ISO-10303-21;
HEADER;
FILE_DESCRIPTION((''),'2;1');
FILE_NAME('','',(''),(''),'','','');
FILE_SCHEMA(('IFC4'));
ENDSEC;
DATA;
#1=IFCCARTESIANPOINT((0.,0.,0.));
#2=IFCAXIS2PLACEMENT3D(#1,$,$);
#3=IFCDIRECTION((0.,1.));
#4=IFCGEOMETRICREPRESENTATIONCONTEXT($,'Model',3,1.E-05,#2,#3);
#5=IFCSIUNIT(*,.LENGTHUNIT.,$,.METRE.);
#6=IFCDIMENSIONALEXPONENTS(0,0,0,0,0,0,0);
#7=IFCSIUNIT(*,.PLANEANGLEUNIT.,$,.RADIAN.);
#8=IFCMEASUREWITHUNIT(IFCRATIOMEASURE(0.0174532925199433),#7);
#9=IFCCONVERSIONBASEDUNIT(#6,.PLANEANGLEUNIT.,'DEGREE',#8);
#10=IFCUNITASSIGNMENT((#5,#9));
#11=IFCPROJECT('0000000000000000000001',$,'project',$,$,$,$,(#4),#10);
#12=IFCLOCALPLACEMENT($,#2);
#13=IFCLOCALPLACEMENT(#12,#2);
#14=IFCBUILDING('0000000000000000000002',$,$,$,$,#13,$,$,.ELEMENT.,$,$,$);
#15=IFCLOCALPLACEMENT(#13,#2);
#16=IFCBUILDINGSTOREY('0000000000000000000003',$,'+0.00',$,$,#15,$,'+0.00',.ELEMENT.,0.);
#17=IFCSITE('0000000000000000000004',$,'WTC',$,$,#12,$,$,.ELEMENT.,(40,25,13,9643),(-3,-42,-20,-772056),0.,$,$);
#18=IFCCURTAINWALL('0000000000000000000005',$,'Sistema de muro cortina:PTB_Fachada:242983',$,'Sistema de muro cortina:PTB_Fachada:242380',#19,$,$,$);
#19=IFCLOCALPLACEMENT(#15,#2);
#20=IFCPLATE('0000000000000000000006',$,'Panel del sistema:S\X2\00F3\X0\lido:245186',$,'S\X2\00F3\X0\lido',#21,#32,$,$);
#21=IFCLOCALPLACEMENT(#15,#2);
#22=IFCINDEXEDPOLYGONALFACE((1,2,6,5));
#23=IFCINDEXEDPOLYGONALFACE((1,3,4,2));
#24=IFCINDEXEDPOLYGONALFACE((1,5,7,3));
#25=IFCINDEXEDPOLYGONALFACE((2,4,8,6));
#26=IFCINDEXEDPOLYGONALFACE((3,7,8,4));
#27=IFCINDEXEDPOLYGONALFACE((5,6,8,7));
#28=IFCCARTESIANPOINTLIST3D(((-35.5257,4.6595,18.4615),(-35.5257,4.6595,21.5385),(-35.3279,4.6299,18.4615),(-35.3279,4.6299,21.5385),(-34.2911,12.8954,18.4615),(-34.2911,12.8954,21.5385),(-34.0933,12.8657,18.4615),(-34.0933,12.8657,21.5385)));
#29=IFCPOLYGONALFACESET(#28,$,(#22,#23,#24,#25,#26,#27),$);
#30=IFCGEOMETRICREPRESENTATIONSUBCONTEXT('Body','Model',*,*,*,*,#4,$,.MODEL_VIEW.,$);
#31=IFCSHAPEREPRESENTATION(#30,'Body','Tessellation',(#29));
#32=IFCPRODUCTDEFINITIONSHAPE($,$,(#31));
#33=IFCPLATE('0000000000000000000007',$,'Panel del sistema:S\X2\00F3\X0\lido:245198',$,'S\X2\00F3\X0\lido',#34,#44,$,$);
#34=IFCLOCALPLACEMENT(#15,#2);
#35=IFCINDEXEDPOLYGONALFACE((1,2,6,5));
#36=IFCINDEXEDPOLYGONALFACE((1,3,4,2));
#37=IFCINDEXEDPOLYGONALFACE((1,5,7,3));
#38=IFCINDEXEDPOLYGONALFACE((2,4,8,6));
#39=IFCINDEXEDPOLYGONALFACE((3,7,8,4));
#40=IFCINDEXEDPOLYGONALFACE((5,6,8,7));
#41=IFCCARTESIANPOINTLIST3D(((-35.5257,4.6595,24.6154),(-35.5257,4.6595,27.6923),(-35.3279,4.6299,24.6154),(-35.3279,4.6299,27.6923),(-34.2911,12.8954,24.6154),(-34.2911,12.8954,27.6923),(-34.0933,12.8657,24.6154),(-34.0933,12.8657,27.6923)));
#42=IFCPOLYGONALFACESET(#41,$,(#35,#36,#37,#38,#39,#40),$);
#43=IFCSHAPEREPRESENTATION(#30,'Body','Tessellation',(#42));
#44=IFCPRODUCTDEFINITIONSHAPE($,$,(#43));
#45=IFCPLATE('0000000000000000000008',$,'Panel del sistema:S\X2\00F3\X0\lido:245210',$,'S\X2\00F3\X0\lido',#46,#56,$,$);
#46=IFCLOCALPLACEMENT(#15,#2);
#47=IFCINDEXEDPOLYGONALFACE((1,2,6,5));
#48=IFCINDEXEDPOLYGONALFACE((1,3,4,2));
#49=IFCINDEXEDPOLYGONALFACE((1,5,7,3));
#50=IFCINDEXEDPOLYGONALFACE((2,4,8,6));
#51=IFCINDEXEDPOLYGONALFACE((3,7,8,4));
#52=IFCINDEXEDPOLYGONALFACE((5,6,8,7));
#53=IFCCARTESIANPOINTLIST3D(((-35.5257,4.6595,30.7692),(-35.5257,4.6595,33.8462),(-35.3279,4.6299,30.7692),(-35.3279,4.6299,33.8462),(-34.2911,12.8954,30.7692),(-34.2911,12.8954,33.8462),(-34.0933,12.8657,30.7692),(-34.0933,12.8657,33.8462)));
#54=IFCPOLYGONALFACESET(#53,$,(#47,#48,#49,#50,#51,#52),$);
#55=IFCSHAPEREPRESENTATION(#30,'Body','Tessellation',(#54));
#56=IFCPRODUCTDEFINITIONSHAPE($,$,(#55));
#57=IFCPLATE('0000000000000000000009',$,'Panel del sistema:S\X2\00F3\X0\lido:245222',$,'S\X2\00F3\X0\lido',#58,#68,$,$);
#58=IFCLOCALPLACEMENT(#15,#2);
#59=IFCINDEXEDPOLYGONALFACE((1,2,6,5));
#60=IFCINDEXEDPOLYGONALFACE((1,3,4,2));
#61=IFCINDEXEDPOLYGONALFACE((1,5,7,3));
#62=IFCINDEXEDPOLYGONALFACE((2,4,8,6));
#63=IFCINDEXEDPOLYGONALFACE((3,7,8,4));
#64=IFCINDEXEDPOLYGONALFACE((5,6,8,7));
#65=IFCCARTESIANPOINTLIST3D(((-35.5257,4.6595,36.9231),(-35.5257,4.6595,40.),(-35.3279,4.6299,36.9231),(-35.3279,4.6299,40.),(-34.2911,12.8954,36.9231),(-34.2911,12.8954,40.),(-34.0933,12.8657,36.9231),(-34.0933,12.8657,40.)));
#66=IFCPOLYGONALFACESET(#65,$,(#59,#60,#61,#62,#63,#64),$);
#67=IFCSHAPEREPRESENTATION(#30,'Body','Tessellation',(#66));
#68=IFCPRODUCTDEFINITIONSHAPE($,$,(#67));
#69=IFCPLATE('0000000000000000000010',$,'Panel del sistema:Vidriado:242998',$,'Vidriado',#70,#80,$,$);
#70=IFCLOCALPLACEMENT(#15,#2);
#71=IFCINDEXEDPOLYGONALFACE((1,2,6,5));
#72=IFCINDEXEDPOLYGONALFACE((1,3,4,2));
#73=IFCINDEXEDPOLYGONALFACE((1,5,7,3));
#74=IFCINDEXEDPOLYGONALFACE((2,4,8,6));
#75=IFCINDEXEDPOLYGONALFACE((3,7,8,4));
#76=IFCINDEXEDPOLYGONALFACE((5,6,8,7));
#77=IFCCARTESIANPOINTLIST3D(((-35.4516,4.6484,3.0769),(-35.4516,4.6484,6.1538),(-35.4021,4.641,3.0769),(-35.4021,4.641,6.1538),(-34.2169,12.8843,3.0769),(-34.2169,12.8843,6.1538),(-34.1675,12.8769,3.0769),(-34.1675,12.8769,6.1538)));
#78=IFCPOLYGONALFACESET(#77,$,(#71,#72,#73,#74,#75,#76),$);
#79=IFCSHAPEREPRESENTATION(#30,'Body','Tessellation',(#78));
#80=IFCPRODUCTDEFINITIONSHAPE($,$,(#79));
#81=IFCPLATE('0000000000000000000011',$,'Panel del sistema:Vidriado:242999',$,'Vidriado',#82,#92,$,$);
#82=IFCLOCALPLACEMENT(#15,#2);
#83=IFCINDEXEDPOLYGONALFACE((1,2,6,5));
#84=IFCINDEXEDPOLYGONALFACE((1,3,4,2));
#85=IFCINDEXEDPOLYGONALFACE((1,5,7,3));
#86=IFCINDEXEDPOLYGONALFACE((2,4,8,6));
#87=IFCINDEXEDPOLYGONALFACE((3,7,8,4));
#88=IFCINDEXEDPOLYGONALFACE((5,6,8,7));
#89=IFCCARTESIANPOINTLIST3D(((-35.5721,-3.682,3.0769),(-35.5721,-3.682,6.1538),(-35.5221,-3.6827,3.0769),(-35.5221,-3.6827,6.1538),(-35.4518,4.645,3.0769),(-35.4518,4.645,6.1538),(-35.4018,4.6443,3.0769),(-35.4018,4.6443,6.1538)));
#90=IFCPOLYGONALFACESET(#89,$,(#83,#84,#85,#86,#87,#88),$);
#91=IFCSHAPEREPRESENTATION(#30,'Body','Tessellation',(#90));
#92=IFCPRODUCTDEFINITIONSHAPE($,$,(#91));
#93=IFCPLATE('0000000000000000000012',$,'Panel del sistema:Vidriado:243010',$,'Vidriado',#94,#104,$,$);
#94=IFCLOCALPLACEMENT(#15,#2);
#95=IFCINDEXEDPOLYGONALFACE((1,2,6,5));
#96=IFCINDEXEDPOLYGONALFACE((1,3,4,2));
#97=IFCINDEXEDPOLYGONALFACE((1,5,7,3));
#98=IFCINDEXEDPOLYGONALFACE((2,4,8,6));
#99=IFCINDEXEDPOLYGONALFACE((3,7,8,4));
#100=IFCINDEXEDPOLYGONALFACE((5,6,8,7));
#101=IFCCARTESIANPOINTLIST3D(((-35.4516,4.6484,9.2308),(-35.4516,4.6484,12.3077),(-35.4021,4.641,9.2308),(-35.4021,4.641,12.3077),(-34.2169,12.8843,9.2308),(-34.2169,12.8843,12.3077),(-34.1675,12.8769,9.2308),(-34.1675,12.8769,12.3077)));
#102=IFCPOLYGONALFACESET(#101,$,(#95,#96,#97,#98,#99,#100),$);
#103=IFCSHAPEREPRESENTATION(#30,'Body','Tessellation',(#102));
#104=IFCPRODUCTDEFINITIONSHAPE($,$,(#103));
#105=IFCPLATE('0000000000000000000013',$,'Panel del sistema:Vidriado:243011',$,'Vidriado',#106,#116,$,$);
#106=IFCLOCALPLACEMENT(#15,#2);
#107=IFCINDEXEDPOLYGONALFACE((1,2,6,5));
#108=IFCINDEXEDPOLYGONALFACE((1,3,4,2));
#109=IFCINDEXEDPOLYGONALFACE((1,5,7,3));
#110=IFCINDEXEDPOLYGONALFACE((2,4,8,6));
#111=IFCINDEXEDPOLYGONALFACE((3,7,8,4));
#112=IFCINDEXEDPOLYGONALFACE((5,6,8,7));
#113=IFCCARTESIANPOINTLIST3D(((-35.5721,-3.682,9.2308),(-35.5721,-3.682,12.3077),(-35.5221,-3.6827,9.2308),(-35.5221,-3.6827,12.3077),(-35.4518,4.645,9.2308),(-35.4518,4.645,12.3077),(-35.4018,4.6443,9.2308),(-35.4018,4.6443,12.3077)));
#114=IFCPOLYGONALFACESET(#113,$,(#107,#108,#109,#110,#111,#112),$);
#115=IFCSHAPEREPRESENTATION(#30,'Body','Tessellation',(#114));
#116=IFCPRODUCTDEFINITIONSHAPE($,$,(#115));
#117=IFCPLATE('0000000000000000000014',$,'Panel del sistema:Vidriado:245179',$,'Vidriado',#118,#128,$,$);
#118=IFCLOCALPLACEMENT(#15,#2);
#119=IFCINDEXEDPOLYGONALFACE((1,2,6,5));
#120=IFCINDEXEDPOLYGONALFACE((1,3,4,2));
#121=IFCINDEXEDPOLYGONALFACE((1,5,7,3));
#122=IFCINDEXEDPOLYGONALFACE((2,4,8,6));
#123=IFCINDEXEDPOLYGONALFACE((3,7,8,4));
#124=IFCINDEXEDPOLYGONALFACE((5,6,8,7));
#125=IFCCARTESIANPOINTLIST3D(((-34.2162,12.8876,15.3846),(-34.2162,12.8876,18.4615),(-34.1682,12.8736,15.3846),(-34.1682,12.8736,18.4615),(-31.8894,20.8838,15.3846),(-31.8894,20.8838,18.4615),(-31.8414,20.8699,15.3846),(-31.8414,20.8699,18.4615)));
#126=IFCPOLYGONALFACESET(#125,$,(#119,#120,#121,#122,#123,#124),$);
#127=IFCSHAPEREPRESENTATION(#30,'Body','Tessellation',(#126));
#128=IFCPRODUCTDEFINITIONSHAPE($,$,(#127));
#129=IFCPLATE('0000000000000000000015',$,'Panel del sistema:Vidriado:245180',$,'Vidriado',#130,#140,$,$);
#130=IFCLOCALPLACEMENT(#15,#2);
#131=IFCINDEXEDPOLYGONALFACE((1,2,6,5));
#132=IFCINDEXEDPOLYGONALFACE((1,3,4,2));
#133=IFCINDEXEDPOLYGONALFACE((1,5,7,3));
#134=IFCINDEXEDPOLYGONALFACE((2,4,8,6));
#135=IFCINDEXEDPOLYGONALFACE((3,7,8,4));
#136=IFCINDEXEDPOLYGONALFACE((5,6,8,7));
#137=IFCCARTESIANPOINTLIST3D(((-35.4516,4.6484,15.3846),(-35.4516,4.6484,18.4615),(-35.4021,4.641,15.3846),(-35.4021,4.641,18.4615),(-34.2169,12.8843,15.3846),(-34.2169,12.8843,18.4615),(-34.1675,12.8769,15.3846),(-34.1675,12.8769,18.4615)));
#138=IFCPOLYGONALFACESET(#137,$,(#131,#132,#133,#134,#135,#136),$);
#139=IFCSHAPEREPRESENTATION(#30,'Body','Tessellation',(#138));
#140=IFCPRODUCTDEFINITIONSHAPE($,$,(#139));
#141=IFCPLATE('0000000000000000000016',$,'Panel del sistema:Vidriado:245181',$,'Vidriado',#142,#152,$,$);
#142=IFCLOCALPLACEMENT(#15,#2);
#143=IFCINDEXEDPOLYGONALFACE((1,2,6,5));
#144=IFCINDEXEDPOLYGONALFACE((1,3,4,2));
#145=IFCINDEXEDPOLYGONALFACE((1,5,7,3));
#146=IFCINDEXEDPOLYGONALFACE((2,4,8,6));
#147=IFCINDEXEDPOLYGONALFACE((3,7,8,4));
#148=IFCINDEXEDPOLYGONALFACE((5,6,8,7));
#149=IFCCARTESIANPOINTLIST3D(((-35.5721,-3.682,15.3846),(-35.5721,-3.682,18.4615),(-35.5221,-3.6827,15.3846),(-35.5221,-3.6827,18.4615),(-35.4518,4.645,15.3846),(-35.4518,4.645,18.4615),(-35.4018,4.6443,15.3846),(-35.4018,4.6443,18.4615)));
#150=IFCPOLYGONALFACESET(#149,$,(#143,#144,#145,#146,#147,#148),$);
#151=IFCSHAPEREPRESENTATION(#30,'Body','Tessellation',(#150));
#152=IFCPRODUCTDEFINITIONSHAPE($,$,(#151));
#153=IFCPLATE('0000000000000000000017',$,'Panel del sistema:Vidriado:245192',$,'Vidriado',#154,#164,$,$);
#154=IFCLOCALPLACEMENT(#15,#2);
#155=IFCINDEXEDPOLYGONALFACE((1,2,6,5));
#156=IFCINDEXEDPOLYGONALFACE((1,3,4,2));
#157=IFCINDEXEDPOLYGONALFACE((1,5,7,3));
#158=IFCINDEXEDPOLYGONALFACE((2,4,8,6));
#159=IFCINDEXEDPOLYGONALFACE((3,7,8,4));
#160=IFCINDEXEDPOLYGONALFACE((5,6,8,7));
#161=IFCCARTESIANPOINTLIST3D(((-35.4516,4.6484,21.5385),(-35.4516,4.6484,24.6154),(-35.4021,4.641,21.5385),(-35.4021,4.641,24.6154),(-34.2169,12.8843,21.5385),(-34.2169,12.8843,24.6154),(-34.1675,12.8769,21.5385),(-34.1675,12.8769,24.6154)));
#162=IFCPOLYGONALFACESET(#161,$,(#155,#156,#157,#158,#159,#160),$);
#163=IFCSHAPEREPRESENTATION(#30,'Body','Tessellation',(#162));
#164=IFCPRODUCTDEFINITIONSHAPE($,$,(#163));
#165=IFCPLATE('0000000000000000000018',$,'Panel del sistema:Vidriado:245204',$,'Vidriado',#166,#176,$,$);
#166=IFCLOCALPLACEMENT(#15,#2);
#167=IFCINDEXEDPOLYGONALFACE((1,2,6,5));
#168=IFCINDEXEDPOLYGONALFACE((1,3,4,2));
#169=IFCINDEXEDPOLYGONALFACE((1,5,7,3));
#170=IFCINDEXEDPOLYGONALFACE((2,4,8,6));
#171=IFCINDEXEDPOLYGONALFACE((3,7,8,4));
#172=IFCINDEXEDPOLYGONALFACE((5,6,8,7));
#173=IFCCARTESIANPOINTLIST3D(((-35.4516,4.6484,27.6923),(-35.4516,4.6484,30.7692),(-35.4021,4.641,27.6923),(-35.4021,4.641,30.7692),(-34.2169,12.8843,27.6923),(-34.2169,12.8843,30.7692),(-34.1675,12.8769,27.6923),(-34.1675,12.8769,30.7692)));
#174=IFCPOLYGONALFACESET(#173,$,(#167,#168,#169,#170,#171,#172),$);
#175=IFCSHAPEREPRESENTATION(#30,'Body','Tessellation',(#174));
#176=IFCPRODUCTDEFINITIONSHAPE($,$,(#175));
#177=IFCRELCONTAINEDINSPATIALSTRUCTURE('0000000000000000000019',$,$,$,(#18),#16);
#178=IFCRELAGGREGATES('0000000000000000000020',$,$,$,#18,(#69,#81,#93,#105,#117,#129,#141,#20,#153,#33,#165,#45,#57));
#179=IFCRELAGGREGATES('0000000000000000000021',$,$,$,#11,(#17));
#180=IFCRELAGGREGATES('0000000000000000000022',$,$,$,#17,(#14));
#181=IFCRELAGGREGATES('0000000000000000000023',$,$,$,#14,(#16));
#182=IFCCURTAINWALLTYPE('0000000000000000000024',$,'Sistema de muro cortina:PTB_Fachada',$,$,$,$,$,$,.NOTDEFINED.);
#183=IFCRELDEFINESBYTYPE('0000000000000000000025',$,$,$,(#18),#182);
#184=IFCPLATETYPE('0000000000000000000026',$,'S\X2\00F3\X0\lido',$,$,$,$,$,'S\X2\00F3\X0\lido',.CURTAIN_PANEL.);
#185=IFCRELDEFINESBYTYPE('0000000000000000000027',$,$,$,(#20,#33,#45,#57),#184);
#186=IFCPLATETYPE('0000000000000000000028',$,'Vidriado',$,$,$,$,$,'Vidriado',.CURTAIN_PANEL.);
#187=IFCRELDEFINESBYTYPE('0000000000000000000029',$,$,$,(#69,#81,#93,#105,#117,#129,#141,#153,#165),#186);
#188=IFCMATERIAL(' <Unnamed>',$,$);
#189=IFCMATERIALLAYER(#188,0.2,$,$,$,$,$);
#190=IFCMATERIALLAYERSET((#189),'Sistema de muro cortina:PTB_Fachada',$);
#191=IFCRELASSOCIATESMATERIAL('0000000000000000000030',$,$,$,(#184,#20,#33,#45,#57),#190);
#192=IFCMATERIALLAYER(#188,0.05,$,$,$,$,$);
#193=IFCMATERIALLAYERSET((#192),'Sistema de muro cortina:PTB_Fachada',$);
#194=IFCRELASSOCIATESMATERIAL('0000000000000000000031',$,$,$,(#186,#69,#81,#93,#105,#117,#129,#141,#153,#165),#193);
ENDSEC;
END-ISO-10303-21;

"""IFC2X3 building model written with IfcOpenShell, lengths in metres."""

from ifc_helpers import new_model, entity, si_unit, converted_unit, direction, frame, frame_2d, origin, origin_2d_with_axis, place, context, subcontext, project, spatial, rectangle, extrude, source, transform, mapped, material, layer, layer_set, layer_usage, type_object, type_shapes, element, aggregate, save


model = new_model("IFC2X3")

# Units and contexts
model_context = context("Model", 3, precision=1e-05, world=origin(), true_north=direction((0.0, 1.0)))
body_context = subcontext(model_context, "Body", "Model", "MODEL_VIEW")
ifc_project = project(units=[si_unit("LENGTHUNIT", "METRE"), converted_unit("PLANEANGLEUNIT", "DEGREE", entity("IfcRatioMeasure", 0.0174532925199433), si_unit("PLANEANGLEUNIT", "RADIAN"), dimensions=[0, 0, 0, 0, 0, 0, 0])], contexts=[model_context])

# Site, building, storey
site_placement = place(None, origin())
site = spatial("IfcSite", under=ifc_project, at=site_placement, Name="WTC", CompositionType="ELEMENT", RefLatitude=(40, 25, 13, 9643), RefLongitude=(-3, -42, -20, -772056), RefElevation=0.0)
building_placement = place(site_placement, origin())
building = spatial("IfcBuilding", under=site, at=building_placement, CompositionType="ELEMENT")
storey_placement = place(building_placement, origin())
storey = spatial("IfcBuildingStorey", under=building, at=storey_placement, Name="+0.00", LongName="+0.00", CompositionType="ELEMENT", Elevation=0.0)

# Curtain wall, plates
curtain_wall_type = type_object("IfcCurtainWallType", Name="Sistema de muro cortina:PTB_Fachada", PredefinedType="NOTDEFINED")
ifc_material_1 = material(Name=" <Unnamed>")
ifc_layer_1 = layer(ifc_material_1, 0.2)
ifc_layer_set_1 = layer_set([ifc_layer_1], Name="Sistema de muro cortina:PTB_Fachada")
ifc_layer_2 = layer(ifc_material_1, 0.05)
ifc_layer_set_2 = layer_set([ifc_layer_2], Name="Sistema de muro cortina:PTB_Fachada")
curtain_wall_1_placement = place(storey_placement, origin())
curtain_wall_1 = element("IfcCurtainWall", 1, at=curtain_wall_1_placement, inside=storey, type_object=curtain_wall_type, Name="Sistema de muro cortina:PTB_Fachada:242983", ObjectType="Sistema de muro cortina:PTB_Fachada:242380")
plate_type_1 = type_object("IfcPlateType", Name="Sólido", ElementType="Sólido", PredefinedType="CURTAIN_PANEL", material=ifc_layer_set_1)
shared_shape_1 = source(origin(), body_context, "Body", "SweptSolid", [
    extrude(rectangle(XDim=0.2, YDim=8.3279, at=origin_2d_with_axis()), frame((0.0, 0.0, 0.0), z_axis=(0.0, 0.0, 1.0), x_axis=(0.0, 1.0, 0.0)), (0.0, 0.0, 1.0), 3.0769),
])
type_shapes(plate_type_1, [shared_shape_1])
ifc_layer_usage_1 = layer_usage(ifc_layer_set_1, "AXIS3", "POSITIVE", 0.0)
plate_1_placement = place(curtain_wall_1_placement, frame((-34.8095, 8.7626, 21.5385), z_axis=(0.0, 0.0, -1.0), x_axis=(-0.148255, -0.988949, 0.0)))
plate_1 = element("IfcPlate", 2, at=plate_1_placement, type_object=plate_type_1, material=ifc_layer_usage_1, Name="Panel del sistema:Sólido:245186", ObjectType="Sólido", context=body_context, shape_type="MappedRepresentation", body=[
    mapped(shared_shape_1, transform((0.0, 0.0, 0.0), scale=1.0)),
])
ifc_layer_usage_2 = layer_usage(ifc_layer_set_1, "AXIS3", "POSITIVE", 0.0)
plate_2_placement = place(curtain_wall_1_placement, frame((-34.8095, 8.7626, 27.6923), z_axis=(0.0, 0.0, -1.0), x_axis=(-0.148255, -0.988949, 0.0)))
plate_2 = element("IfcPlate", 3, at=plate_2_placement, type_object=plate_type_1, material=ifc_layer_usage_2, Name="Panel del sistema:Sólido:245198", ObjectType="Sólido", context=body_context, shape_type="MappedRepresentation", body=[
    mapped(shared_shape_1, transform((0.0, 0.0, 0.0), scale=1.0)),
])
ifc_layer_usage_3 = layer_usage(ifc_layer_set_1, "AXIS3", "POSITIVE", 0.0)
plate_3_placement = place(curtain_wall_1_placement, frame((-34.8095, 8.7626, 33.8462), z_axis=(0.0, 0.0, -1.0), x_axis=(-0.148255, -0.988949, 0.0)))
plate_3 = element("IfcPlate", 4, at=plate_3_placement, type_object=plate_type_1, material=ifc_layer_usage_3, Name="Panel del sistema:Sólido:245210", ObjectType="Sólido", context=body_context, shape_type="MappedRepresentation", body=[
    mapped(shared_shape_1, transform((0.0, 0.0, 0.0), scale=1.0)),
])
ifc_layer_usage_4 = layer_usage(ifc_layer_set_1, "AXIS3", "POSITIVE", 0.0)
plate_4_placement = place(curtain_wall_1_placement, frame((-34.8095, 8.7626, 40.0), z_axis=(0.0, 0.0, -1.0), x_axis=(-0.148255, -0.988949, 0.0)))
plate_4 = element("IfcPlate", 5, at=plate_4_placement, type_object=plate_type_1, material=ifc_layer_usage_4, Name="Panel del sistema:Sólido:245222", ObjectType="Sólido", context=body_context, shape_type="MappedRepresentation", body=[
    mapped(shared_shape_1, transform((0.0, 0.0, 0.0), scale=1.0)),
])
ifc_layer_usage_5 = layer_usage(ifc_layer_set_2, "AXIS3", "POSITIVE", 0.0)
plate_type_2 = type_object("IfcPlateType", Name="Vidriado", ElementType="Vidriado", PredefinedType="CURTAIN_PANEL", material=ifc_layer_set_2)
shared_shape_2 = source(origin(), body_context, "Body", "SweptSolid", [
    extrude(rectangle(XDim=0.05, YDim=8.3279, at=frame_2d((0.0, 0.0), x_axis=(1.0, 0.0))), frame((0.0, 0.0, 0.0), z_axis=(0.0, 0.0, 1.0), x_axis=(0.0, 1.0, 0.0)), (0.0, 0.0, 1.0), 3.0769),
])
type_shapes(plate_type_2, [shared_shape_2])
plate_5_placement = place(curtain_wall_1_placement, frame((-34.8095, 8.7626, 6.1538), z_axis=(0.0, 0.0, -1.0), x_axis=(-0.148255, -0.988949, 0.0)))
plate_5 = element("IfcPlate", 6, at=plate_5_placement, type_object=plate_type_2, material=ifc_layer_usage_5, Name="Panel del sistema:Vidriado:242998", ObjectType="Vidriado", context=body_context, shape_type="MappedRepresentation", body=[
    mapped(shared_shape_2, transform((0.0, 0.0, 0.0), scale=1.0)),
])
ifc_layer_usage_6 = layer_usage(ifc_layer_set_2, "AXIS3", "POSITIVE", 0.0)
plate_6_placement = place(curtain_wall_1_placement, frame((-35.487, 0.4812, 6.1538), z_axis=(0.0, 0.0, -1.0), x_axis=(-0.014441, -0.999896, 0.0)))
plate_6 = element("IfcPlate", 7, at=plate_6_placement, type_object=plate_type_2, material=ifc_layer_usage_6, Name="Panel del sistema:Vidriado:242999", ObjectType="Vidriado", context=body_context, shape_type="MappedRepresentation", body=[
    mapped(shared_shape_2, transform((0.0, 0.0, 0.0), scale=1.0)),
])
ifc_layer_usage_7 = layer_usage(ifc_layer_set_2, "AXIS3", "POSITIVE", 0.0)
plate_7_placement = place(curtain_wall_1_placement, frame((-34.8095, 8.7626, 12.3077), z_axis=(0.0, 0.0, -1.0), x_axis=(-0.148255, -0.988949, 0.0)))
plate_7 = element("IfcPlate", 8, at=plate_7_placement, type_object=plate_type_2, material=ifc_layer_usage_7, Name="Panel del sistema:Vidriado:243010", ObjectType="Vidriado", context=body_context, shape_type="MappedRepresentation", body=[
    mapped(shared_shape_2, transform((0.0, 0.0, 0.0), scale=1.0)),
])
ifc_layer_usage_8 = layer_usage(ifc_layer_set_2, "AXIS3", "POSITIVE", 0.0)
plate_8_placement = place(curtain_wall_1_placement, frame((-35.487, 0.4812, 12.3077), z_axis=(0.0, 0.0, -1.0), x_axis=(-0.014441, -0.999896, 0.0)))
plate_8 = element("IfcPlate", 9, at=plate_8_placement, type_object=plate_type_2, material=ifc_layer_usage_8, Name="Panel del sistema:Vidriado:243011", ObjectType="Vidriado", context=body_context, shape_type="MappedRepresentation", body=[
    mapped(shared_shape_2, transform((0.0, 0.0, 0.0), scale=1.0)),
])
ifc_layer_usage_9 = layer_usage(ifc_layer_set_2, "AXIS3", "POSITIVE", 0.0)
plate_9_placement = place(curtain_wall_1_placement, frame((-33.0288, 16.8787, 18.4615), z_axis=(0.0, 0.0, -1.0), x_axis=(-0.279396, -0.960176, 0.0)))
plate_9 = element("IfcPlate", 10, at=plate_9_placement, type_object=plate_type_2, material=ifc_layer_usage_9, Name="Panel del sistema:Vidriado:245179", ObjectType="Vidriado", context=body_context, shape_type="MappedRepresentation", body=[
    mapped(shared_shape_2, transform((0.0, 0.0, 0.0), scale=1.0)),
])
ifc_layer_usage_10 = layer_usage(ifc_layer_set_2, "AXIS3", "POSITIVE", 0.0)
plate_10_placement = place(curtain_wall_1_placement, frame((-34.8095, 8.7626, 18.4615), z_axis=(0.0, 0.0, -1.0), x_axis=(-0.148255, -0.988949, 0.0)))
plate_10 = element("IfcPlate", 11, at=plate_10_placement, type_object=plate_type_2, material=ifc_layer_usage_10, Name="Panel del sistema:Vidriado:245180", ObjectType="Vidriado", context=body_context, shape_type="MappedRepresentation", body=[
    mapped(shared_shape_2, transform((0.0, 0.0, 0.0), scale=1.0)),
])
ifc_layer_usage_11 = layer_usage(ifc_layer_set_2, "AXIS3", "POSITIVE", 0.0)
plate_11_placement = place(curtain_wall_1_placement, frame((-35.487, 0.4812, 18.4615), z_axis=(0.0, 0.0, -1.0), x_axis=(-0.014441, -0.999896, 0.0)))
plate_11 = element("IfcPlate", 12, at=plate_11_placement, type_object=plate_type_2, material=ifc_layer_usage_11, Name="Panel del sistema:Vidriado:245181", ObjectType="Vidriado", context=body_context, shape_type="MappedRepresentation", body=[
    mapped(shared_shape_2, transform((0.0, 0.0, 0.0), scale=1.0)),
])
ifc_layer_usage_12 = layer_usage(ifc_layer_set_2, "AXIS3", "POSITIVE", 0.0)
plate_12_placement = place(curtain_wall_1_placement, frame((-34.8095, 8.7626, 24.6154), z_axis=(0.0, 0.0, -1.0), x_axis=(-0.148255, -0.988949, 0.0)))
plate_12 = element("IfcPlate", 13, at=plate_12_placement, type_object=plate_type_2, material=ifc_layer_usage_12, Name="Panel del sistema:Vidriado:245192", ObjectType="Vidriado", context=body_context, shape_type="MappedRepresentation", body=[
    mapped(shared_shape_2, transform((0.0, 0.0, 0.0), scale=1.0)),
])
ifc_layer_usage_13 = layer_usage(ifc_layer_set_2, "AXIS3", "POSITIVE", 0.0)
plate_13_placement = place(curtain_wall_1_placement, frame((-34.8095, 8.7626, 30.7692), z_axis=(0.0, 0.0, -1.0), x_axis=(-0.148255, -0.988949, 0.0)))
plate_13 = element("IfcPlate", 14, at=plate_13_placement, type_object=plate_type_2, material=ifc_layer_usage_13, Name="Panel del sistema:Vidriado:245204", ObjectType="Vidriado", context=body_context, shape_type="MappedRepresentation", body=[
    mapped(shared_shape_2, transform((0.0, 0.0, 0.0), scale=1.0)),
])
aggregate(curtain_wall_1, [plate_5, plate_6, plate_7, plate_8, plate_9, plate_10, plate_11, plate_1, plate_12, plate_2, plate_13, plate_3, plate_4])

save(model, "model.ifc")
